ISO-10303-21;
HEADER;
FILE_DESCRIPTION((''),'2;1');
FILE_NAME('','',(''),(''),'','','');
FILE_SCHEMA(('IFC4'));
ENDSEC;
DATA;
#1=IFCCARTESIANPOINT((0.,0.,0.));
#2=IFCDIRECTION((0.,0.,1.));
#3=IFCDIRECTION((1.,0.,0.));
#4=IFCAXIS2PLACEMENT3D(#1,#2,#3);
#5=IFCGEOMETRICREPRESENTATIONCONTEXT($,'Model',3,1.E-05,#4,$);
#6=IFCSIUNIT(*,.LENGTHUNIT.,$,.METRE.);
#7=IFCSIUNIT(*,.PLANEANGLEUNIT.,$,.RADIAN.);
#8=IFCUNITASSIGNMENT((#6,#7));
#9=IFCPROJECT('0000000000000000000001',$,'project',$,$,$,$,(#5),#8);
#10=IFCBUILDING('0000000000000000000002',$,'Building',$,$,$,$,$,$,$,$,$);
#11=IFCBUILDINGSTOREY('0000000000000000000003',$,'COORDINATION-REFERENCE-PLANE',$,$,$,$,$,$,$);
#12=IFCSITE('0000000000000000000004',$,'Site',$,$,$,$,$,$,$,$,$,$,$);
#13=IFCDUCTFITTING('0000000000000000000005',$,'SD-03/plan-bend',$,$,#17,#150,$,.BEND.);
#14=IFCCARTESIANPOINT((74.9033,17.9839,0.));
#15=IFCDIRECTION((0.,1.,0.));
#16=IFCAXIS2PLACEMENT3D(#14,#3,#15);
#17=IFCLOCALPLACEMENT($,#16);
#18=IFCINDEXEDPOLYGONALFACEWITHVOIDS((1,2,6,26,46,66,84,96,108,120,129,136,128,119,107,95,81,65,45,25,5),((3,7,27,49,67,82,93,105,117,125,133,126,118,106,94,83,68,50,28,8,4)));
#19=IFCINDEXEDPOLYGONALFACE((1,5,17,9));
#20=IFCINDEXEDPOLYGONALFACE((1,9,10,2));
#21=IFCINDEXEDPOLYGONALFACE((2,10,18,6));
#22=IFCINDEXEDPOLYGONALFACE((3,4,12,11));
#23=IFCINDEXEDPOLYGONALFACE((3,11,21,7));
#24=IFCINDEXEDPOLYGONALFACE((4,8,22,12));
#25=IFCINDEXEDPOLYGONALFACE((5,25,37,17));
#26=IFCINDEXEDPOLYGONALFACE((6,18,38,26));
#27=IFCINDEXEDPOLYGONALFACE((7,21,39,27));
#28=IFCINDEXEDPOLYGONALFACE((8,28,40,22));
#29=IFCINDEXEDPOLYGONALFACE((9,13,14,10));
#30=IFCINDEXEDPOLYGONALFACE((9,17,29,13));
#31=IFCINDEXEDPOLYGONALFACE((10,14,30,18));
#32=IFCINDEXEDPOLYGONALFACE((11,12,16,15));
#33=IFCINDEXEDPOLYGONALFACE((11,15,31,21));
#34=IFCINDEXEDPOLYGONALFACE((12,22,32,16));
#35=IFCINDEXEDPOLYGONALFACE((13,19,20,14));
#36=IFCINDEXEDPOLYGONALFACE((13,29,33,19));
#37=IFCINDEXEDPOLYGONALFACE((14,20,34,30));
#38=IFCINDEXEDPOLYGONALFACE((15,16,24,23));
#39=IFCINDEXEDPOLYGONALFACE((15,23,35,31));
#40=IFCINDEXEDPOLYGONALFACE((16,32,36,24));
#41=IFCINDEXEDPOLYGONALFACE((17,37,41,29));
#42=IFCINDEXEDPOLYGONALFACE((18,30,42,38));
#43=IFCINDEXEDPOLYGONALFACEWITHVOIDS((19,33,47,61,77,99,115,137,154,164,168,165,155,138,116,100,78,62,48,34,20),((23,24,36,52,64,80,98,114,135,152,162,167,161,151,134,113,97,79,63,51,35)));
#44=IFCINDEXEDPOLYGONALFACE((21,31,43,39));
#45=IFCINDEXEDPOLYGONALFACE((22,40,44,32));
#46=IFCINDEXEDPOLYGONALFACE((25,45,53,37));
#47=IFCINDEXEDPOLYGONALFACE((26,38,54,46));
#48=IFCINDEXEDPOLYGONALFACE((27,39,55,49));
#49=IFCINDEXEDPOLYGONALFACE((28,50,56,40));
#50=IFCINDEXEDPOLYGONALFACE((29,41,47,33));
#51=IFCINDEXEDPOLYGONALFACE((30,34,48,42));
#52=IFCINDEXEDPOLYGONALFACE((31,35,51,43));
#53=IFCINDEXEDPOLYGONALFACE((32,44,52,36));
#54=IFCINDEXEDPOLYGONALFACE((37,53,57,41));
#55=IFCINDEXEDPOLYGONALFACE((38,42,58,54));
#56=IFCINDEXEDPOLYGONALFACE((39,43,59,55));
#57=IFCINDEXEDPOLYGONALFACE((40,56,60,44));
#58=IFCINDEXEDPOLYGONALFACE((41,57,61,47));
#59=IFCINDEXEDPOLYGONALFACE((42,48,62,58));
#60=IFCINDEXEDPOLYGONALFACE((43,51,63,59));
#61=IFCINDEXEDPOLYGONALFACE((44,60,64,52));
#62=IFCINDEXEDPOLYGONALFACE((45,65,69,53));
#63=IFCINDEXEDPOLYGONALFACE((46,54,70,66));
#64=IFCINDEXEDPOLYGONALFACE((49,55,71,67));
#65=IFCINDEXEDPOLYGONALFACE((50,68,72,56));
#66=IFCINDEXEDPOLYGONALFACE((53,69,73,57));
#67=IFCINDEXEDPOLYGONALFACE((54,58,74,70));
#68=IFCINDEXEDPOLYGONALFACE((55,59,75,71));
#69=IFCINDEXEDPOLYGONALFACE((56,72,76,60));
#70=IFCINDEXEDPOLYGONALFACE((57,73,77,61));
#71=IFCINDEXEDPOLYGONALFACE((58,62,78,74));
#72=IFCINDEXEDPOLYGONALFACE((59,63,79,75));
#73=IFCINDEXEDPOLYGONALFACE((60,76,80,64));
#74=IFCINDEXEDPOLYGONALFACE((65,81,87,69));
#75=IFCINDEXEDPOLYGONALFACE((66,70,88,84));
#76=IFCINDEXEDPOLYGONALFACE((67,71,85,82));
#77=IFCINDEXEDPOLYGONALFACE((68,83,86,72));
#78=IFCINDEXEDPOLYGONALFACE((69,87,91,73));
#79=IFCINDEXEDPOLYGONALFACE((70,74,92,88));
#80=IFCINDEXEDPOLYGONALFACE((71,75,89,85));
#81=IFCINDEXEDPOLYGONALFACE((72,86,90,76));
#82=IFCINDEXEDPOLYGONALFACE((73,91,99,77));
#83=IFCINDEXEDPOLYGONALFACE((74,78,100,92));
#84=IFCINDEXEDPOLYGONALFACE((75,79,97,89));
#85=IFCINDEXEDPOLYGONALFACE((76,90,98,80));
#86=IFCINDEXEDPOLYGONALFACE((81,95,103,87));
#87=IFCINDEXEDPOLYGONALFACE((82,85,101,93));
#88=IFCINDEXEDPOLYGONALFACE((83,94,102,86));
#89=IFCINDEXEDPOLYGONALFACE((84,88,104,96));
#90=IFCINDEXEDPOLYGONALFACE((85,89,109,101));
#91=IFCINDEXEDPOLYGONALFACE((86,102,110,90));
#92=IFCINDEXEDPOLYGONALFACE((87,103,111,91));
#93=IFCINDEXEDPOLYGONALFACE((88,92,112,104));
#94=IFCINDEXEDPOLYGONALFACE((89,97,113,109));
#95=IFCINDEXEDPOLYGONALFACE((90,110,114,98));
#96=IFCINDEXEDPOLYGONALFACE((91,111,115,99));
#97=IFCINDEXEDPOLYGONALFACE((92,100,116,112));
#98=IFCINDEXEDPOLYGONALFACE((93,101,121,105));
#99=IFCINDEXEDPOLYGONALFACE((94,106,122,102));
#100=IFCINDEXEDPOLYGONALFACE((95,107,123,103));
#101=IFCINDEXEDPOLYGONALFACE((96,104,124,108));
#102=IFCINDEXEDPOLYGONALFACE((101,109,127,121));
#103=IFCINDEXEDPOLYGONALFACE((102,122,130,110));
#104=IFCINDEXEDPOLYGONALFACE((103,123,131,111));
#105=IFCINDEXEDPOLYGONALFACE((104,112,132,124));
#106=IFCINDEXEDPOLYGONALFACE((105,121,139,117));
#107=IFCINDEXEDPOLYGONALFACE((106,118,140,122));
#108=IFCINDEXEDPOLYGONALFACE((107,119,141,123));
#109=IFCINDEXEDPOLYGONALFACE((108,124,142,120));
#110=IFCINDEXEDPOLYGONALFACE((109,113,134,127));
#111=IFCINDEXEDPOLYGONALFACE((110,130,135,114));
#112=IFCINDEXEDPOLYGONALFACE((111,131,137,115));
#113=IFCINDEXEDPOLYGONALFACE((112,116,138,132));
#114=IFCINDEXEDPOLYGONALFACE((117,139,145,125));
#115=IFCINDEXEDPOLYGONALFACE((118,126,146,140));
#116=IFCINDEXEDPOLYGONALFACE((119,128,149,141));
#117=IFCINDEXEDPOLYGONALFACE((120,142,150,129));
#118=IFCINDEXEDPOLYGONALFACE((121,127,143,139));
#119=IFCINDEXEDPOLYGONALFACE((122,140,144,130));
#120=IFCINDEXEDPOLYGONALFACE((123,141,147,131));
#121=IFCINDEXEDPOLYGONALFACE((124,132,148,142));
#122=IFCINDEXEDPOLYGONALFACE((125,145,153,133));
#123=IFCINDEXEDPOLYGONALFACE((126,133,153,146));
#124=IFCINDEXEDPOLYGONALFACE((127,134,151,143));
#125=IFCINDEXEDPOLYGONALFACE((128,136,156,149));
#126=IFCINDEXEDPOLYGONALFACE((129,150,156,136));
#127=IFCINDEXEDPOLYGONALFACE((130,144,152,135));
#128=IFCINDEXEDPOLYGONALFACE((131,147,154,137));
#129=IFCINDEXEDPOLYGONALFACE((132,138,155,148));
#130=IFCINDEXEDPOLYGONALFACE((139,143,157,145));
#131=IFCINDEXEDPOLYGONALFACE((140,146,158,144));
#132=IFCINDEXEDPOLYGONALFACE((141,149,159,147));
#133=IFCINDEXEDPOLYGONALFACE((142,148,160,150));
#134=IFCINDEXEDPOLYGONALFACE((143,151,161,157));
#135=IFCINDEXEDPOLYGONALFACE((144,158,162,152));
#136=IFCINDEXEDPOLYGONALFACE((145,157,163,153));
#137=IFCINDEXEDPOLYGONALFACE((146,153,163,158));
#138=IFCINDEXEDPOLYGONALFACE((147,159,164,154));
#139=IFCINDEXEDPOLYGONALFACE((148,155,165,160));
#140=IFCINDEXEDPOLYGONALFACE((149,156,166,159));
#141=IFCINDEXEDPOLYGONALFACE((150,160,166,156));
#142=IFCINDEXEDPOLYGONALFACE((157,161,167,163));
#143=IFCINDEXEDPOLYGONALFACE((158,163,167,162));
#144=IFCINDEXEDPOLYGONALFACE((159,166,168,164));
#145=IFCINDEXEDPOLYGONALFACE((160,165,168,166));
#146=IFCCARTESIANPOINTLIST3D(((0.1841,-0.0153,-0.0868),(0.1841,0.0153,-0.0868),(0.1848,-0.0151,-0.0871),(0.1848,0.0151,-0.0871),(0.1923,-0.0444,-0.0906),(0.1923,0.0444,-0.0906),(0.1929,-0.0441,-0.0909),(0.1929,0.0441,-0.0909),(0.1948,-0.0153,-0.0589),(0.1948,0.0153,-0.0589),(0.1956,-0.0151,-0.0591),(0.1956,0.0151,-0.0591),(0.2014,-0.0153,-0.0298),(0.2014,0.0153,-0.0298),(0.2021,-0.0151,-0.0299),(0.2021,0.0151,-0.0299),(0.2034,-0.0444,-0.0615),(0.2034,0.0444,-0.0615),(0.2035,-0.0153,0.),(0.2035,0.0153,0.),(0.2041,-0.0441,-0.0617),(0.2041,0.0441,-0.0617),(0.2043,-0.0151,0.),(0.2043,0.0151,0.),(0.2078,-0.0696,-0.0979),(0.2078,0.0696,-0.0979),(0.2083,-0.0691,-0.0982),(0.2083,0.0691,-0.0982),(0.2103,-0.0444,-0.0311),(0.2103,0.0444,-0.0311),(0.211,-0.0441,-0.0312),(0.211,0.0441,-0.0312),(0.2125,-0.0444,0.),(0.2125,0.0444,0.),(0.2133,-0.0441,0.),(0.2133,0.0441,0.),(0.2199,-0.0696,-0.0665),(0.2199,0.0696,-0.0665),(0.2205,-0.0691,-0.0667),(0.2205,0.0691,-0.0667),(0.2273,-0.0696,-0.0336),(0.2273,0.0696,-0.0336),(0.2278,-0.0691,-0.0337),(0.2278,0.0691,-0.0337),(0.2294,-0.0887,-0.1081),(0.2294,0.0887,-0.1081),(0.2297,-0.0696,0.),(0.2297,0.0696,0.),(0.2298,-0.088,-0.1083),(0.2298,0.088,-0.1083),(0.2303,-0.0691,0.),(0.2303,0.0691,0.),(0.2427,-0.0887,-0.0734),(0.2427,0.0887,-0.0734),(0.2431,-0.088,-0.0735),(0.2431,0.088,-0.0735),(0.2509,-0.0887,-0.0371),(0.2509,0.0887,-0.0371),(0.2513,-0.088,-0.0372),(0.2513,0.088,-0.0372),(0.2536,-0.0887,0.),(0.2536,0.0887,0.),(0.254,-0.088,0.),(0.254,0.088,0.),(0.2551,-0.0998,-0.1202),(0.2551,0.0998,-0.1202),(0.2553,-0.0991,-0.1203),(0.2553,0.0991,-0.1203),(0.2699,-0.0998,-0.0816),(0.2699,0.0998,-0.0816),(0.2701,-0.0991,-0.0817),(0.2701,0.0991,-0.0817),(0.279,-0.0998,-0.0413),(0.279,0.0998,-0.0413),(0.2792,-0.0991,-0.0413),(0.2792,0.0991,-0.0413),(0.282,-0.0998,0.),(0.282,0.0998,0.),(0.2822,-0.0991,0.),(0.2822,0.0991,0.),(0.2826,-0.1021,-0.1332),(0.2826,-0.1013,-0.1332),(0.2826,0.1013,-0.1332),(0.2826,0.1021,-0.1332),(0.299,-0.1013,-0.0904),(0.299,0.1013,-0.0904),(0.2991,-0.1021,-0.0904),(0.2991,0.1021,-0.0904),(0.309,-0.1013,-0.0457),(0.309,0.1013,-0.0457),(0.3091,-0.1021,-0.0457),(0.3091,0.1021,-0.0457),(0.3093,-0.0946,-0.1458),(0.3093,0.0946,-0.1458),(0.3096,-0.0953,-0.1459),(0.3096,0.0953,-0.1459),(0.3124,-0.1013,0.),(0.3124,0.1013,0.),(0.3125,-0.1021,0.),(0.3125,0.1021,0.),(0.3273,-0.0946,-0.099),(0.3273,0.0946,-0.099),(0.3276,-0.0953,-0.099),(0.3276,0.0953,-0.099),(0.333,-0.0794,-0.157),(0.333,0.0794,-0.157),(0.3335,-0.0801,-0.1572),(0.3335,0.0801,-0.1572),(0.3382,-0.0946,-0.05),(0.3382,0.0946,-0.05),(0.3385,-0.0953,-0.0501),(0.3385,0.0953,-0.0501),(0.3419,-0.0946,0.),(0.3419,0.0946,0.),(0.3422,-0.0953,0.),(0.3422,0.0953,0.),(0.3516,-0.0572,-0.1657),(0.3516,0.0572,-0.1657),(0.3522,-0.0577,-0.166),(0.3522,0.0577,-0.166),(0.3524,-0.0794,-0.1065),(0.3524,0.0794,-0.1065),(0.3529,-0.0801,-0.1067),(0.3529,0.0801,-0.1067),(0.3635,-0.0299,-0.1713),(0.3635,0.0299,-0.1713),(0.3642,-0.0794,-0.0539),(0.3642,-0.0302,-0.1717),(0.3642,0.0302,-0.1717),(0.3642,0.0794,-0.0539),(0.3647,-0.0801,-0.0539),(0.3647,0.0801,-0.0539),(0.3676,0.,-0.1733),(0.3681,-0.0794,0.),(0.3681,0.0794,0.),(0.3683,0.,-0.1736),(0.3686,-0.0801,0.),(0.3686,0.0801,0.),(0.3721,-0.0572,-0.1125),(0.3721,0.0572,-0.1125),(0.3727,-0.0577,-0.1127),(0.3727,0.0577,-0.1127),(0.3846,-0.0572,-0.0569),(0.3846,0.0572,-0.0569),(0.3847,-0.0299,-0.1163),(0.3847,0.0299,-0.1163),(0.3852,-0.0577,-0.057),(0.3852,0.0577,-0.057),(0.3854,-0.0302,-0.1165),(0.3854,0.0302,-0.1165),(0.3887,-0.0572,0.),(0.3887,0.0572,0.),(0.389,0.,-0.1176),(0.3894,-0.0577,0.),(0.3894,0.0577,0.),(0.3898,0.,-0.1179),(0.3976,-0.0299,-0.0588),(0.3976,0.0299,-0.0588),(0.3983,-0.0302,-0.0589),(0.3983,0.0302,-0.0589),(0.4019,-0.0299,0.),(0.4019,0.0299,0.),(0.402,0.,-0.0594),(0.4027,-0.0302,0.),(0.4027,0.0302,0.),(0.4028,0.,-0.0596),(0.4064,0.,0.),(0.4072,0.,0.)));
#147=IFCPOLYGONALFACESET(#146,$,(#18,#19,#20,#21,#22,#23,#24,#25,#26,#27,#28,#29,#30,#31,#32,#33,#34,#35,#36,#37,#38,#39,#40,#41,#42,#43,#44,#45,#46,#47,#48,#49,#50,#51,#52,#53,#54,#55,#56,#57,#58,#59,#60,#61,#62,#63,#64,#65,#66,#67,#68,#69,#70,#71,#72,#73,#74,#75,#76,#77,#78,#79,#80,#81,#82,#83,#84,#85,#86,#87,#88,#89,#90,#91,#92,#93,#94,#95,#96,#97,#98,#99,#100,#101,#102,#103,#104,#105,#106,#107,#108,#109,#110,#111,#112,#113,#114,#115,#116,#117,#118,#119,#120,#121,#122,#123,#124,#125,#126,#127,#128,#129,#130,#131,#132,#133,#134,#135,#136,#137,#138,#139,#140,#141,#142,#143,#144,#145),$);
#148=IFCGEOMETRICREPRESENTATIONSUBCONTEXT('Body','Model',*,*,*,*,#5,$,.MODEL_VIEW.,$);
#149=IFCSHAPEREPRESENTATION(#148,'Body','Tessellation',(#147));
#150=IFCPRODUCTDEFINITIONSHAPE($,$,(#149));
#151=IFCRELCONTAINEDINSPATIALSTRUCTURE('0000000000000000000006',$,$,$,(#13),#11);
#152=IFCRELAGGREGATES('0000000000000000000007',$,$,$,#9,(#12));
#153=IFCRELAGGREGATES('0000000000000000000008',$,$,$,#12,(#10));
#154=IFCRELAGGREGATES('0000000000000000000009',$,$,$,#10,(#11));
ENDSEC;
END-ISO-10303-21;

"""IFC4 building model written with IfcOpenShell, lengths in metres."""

from ifc_helpers import new_model, entity, si_unit, frame, origin_with_axes, place, context, subcontext, project, spatial, element, save


model = new_model("IFC4")

# Units and contexts
model_context_1 = context("Model", 3, precision=1e-05, world=origin_with_axes())
body_context_1 = subcontext(model_context_1, "Body", "Model", "MODEL_VIEW")
ifc_project = project(units=[si_unit("LENGTHUNIT", "METRE"), si_unit("PLANEANGLEUNIT", "RADIAN")], contexts=[model_context_1])

# Site, building, storey
site = spatial("IfcSite", under=ifc_project, Name="Site")
building = spatial("IfcBuilding", under=site, Name="Building")
storey = spatial("IfcBuildingStorey", under=building, Name="COORDINATION-REFERENCE-PLANE")

# Duct fitting
duct_fitting_1_placement = place(None, frame((74.9033, 17.9839, 0.0), z_axis=(1.0, 0.0, 0.0), x_axis=(0.0, 1.0, 0.0)))
element("IfcDuctFitting", 1, at=duct_fitting_1_placement, inside=storey, Name="SD-03/plan-bend", PredefinedType="BEND", context=body_context_1, shape_type="SweptSolid", body=[
    entity("IfcRevolvedAreaSolid", entity("IfcCircleHollowProfileDef", "AREA", None, entity("IfcAxis2Placement2D", entity("IfcCartesianPoint", [0.3048, 0.0])), 0.1024, 0.0008), entity("IfcAxis2Placement3D", entity("IfcCartesianPoint", [0.0, 0.0, 0.0]), entity("IfcDirection", [0.0, 0.0, 1.0]), entity("IfcDirection", [1.0, 0.0, 0.0])), entity("IfcAxis1Placement", entity("IfcCartesianPoint", [0.0, 0.0, 0.0]), entity("IfcDirection", [0.0, 1.0, 0.0])), 0.440428),
])

save(model, "model.ifc")
